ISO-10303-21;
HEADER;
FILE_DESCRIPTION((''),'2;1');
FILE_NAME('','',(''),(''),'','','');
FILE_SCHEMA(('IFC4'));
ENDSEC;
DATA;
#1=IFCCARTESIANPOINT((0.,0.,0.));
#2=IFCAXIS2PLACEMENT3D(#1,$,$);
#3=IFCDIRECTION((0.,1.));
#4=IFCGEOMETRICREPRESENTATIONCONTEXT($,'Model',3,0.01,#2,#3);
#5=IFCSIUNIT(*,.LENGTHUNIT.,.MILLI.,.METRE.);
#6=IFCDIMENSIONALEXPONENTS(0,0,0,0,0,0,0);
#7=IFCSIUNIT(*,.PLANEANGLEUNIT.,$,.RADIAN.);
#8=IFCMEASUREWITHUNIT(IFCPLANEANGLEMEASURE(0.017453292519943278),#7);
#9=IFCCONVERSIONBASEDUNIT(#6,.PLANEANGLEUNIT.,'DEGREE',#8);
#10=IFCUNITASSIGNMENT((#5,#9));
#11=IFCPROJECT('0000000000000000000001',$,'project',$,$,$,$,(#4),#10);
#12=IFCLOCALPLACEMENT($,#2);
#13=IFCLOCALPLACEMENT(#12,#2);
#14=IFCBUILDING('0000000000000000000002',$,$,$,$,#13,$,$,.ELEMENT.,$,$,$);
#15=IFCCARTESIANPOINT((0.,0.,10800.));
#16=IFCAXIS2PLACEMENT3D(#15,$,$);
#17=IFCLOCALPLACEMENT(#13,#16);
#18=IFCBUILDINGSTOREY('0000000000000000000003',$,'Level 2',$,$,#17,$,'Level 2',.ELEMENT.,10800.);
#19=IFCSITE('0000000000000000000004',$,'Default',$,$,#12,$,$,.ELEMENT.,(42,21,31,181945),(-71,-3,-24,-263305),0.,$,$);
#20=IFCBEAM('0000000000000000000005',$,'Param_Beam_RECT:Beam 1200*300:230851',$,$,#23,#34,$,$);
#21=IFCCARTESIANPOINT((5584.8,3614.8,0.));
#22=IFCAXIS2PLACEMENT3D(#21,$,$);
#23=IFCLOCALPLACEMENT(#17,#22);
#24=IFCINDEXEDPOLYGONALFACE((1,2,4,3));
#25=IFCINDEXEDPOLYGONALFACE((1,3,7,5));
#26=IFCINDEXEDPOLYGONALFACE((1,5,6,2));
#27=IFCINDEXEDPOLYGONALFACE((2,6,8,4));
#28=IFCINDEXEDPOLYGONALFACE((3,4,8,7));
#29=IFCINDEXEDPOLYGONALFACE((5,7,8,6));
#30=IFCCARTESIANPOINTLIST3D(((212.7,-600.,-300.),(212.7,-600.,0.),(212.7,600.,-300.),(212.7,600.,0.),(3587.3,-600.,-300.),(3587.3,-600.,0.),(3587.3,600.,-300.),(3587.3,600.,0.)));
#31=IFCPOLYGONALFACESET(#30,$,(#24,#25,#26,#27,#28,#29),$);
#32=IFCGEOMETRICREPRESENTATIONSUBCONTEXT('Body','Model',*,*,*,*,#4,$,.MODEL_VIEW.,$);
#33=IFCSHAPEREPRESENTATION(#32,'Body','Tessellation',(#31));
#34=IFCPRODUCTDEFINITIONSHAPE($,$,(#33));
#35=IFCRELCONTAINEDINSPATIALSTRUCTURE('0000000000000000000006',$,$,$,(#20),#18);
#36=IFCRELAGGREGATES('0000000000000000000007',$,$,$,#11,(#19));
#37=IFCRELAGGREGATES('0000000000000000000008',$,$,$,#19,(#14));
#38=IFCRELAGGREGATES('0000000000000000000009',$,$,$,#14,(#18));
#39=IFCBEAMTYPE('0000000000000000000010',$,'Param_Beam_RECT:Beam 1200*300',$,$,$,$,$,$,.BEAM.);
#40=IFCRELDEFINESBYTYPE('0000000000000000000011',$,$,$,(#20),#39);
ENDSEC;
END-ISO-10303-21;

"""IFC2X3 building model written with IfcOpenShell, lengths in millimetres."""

from ifc_helpers import new_model, entity, si_unit, converted_unit, direction, frame, frame_2d, origin, place, context, subcontext, project, spatial, rectangle, extrude, type_object, element, save


model = new_model("IFC2X3")

# Units and contexts
model_context = context("Model", 3, precision=0.01, world=origin(), true_north=direction((0.0, 1.0)))
body_context = subcontext(model_context, "Body", "Model", "MODEL_VIEW")
ifc_project = project(units=[si_unit("LENGTHUNIT", "METRE", prefix="MILLI"), converted_unit("PLANEANGLEUNIT", "DEGREE", entity("IfcPlaneAngleMeasure", 0.017453292519943278), si_unit("PLANEANGLEUNIT", "RADIAN"), dimensions=[0, 0, 0, 0, 0, 0, 0])], contexts=[model_context])

# Site, building, storey
site_placement = place(None, origin())
site = spatial("IfcSite", under=ifc_project, at=site_placement, Name="Default", CompositionType="ELEMENT", RefLatitude=(42, 21, 31, 181945), RefLongitude=(-71, -3, -24, -263305), RefElevation=0.0)
building_placement = place(site_placement, origin())
building = spatial("IfcBuilding", under=site, at=building_placement, CompositionType="ELEMENT")
storey_placement = place(building_placement, frame((0.0, 0.0, 10800.0)))
storey = spatial("IfcBuildingStorey", under=building, at=storey_placement, Name="Level 2", LongName="Level 2", CompositionType="ELEMENT", Elevation=10800.0)

# Beam
beam_type_1 = type_object("IfcBeamType", Name="Param_Beam_RECT:Beam 1200*300", PredefinedType="BEAM")
beam_1_placement = place(storey_placement, frame((5584.8, 3614.8, 0.0)))
element("IfcBeam", 1, at=beam_1_placement, inside=storey, type_object=beam_type_1, Name="Param_Beam_RECT:Beam 1200*300:230851", context=body_context, shape_type="SweptSolid", body=[
    extrude(rectangle(XDim=300.0, YDim=1200.0, at=frame_2d((0.0, 0.0), x_axis=(1.0, 0.0))), frame((212.7, 0.0, -150.0), z_axis=(1.0, 0.0, 0.0), x_axis=(0.0, 0.0, -1.0)), (0.0, 0.0, 1.0), 3374.6),
])

save(model, "model.ifc")
